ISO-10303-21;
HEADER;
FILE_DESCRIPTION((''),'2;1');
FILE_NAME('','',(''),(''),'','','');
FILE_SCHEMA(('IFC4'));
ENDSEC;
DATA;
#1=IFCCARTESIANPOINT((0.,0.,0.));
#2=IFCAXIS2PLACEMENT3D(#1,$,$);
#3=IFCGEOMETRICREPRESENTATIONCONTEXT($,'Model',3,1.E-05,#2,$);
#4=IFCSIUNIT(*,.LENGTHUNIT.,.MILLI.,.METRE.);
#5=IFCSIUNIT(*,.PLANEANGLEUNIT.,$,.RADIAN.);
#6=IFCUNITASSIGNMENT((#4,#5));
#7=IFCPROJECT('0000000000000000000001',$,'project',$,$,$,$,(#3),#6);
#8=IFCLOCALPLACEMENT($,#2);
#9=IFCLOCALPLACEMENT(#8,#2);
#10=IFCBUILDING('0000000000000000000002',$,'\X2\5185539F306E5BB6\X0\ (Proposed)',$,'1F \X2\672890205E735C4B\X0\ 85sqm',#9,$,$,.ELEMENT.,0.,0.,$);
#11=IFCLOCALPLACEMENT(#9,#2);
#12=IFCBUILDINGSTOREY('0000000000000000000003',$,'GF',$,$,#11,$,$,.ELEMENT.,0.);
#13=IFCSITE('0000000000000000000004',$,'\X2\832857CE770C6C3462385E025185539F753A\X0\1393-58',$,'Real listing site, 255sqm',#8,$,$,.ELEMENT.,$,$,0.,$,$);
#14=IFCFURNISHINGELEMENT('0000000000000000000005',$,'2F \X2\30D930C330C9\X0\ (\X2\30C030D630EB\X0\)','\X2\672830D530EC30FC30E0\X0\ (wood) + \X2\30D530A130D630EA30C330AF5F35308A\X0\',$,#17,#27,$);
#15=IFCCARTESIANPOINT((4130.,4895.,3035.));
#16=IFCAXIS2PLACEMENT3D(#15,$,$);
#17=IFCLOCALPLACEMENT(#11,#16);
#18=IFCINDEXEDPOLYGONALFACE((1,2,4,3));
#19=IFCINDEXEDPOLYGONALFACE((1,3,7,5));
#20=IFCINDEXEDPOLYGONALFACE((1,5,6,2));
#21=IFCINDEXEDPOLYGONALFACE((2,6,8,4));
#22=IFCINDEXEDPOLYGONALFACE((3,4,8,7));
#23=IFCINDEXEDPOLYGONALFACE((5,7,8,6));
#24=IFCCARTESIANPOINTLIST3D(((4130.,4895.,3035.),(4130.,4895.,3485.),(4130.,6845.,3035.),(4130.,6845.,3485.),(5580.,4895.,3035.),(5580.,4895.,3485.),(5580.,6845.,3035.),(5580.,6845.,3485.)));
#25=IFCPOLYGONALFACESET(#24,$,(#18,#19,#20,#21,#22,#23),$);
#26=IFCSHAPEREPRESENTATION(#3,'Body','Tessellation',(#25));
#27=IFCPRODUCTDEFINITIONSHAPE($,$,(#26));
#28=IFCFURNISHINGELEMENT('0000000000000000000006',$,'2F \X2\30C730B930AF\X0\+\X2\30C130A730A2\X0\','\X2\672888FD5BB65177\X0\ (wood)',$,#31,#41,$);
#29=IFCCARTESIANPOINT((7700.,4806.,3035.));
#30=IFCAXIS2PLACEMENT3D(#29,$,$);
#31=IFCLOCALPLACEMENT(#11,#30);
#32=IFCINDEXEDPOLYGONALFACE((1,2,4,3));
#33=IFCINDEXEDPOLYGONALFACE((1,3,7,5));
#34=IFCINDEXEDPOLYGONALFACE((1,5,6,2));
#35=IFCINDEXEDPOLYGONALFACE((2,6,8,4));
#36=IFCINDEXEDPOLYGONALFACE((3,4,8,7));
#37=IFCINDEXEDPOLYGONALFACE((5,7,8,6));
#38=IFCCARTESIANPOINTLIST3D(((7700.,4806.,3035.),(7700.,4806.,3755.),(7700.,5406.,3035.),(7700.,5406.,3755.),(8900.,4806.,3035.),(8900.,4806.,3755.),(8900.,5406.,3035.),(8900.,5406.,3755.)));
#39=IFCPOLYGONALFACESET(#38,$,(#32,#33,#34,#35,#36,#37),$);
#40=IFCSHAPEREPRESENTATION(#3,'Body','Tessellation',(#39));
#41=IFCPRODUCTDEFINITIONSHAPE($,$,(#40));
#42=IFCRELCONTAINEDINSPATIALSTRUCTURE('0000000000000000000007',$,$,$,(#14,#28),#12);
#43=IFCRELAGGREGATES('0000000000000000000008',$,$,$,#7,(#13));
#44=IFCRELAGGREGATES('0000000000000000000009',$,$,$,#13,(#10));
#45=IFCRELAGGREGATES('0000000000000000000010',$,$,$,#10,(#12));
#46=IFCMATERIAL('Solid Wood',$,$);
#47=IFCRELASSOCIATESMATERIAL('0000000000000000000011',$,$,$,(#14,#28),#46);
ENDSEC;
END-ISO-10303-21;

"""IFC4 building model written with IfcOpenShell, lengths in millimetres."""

from ifc_helpers import new_model, si_unit, frame, frame_2d, origin, place, context, project, spatial, rectangle, extrude, material, element, save


model = new_model("IFC4")

# Units and contexts
model_context = context("Model", 3, precision=1e-05, world=origin())
ifc_project = project(units=[si_unit("LENGTHUNIT", "METRE", prefix="MILLI"), si_unit("PLANEANGLEUNIT", "RADIAN")], contexts=[model_context])

# Site, building, storey
site_placement = place(None, origin())
site = spatial("IfcSite", under=ifc_project, at=site_placement, Name="茨城県水戸市内原町1393-58", ObjectType="Real listing site, 255sqm", CompositionType="ELEMENT", RefElevation=0.0)
building_placement = place(site_placement, origin())
building = spatial("IfcBuilding", under=site, at=building_placement, Name="内原の家 (Proposed)", ObjectType="1F 木造平屋 85sqm", CompositionType="ELEMENT", ElevationOfRefHeight=0.0, ElevationOfTerrain=0.0)
storey_placement = place(building_placement, origin())
storey = spatial("IfcBuildingStorey", under=building, at=storey_placement, Name="GF", CompositionType="ELEMENT", Elevation=0.0)

# Shared definitions
ifc_material_1 = material(Name="Solid Wood")

# Furnishing elements
furnishing_1_placement = place(storey_placement, frame((4130.0, 4895.0, 3035.0)))
element("IfcFurnishingElement", 1, at=furnishing_1_placement, inside=storey, material=ifc_material_1, Name="2F ベッド (ダブル)", Description="木フレーム (wood) + ファブリック張り", context=model_context, shape_type="SweptSolid", body=[
    extrude(rectangle(XDim=1450.0, YDim=1950.0, at=frame_2d((725.0, 975.0))), frame((4130.0, 4895.0, 3035.0)), (0.0, 0.0, 1.0), 450.0),
])
furnishing_2_placement = place(storey_placement, frame((7700.0, 4806.0, 3035.0)))
element("IfcFurnishingElement", 2, at=furnishing_2_placement, inside=storey, material=ifc_material_1, Name="2F デスク+チェア", Description="木製家具 (wood)", context=model_context, shape_type="SweptSolid", body=[
    extrude(rectangle(XDim=1200.0, YDim=600.0, at=frame_2d((600.0, 300.0))), frame((7700.0, 4806.0, 3035.0)), (0.0, 0.0, 1.0), 720.0),
])

save(model, "model.ifc")
